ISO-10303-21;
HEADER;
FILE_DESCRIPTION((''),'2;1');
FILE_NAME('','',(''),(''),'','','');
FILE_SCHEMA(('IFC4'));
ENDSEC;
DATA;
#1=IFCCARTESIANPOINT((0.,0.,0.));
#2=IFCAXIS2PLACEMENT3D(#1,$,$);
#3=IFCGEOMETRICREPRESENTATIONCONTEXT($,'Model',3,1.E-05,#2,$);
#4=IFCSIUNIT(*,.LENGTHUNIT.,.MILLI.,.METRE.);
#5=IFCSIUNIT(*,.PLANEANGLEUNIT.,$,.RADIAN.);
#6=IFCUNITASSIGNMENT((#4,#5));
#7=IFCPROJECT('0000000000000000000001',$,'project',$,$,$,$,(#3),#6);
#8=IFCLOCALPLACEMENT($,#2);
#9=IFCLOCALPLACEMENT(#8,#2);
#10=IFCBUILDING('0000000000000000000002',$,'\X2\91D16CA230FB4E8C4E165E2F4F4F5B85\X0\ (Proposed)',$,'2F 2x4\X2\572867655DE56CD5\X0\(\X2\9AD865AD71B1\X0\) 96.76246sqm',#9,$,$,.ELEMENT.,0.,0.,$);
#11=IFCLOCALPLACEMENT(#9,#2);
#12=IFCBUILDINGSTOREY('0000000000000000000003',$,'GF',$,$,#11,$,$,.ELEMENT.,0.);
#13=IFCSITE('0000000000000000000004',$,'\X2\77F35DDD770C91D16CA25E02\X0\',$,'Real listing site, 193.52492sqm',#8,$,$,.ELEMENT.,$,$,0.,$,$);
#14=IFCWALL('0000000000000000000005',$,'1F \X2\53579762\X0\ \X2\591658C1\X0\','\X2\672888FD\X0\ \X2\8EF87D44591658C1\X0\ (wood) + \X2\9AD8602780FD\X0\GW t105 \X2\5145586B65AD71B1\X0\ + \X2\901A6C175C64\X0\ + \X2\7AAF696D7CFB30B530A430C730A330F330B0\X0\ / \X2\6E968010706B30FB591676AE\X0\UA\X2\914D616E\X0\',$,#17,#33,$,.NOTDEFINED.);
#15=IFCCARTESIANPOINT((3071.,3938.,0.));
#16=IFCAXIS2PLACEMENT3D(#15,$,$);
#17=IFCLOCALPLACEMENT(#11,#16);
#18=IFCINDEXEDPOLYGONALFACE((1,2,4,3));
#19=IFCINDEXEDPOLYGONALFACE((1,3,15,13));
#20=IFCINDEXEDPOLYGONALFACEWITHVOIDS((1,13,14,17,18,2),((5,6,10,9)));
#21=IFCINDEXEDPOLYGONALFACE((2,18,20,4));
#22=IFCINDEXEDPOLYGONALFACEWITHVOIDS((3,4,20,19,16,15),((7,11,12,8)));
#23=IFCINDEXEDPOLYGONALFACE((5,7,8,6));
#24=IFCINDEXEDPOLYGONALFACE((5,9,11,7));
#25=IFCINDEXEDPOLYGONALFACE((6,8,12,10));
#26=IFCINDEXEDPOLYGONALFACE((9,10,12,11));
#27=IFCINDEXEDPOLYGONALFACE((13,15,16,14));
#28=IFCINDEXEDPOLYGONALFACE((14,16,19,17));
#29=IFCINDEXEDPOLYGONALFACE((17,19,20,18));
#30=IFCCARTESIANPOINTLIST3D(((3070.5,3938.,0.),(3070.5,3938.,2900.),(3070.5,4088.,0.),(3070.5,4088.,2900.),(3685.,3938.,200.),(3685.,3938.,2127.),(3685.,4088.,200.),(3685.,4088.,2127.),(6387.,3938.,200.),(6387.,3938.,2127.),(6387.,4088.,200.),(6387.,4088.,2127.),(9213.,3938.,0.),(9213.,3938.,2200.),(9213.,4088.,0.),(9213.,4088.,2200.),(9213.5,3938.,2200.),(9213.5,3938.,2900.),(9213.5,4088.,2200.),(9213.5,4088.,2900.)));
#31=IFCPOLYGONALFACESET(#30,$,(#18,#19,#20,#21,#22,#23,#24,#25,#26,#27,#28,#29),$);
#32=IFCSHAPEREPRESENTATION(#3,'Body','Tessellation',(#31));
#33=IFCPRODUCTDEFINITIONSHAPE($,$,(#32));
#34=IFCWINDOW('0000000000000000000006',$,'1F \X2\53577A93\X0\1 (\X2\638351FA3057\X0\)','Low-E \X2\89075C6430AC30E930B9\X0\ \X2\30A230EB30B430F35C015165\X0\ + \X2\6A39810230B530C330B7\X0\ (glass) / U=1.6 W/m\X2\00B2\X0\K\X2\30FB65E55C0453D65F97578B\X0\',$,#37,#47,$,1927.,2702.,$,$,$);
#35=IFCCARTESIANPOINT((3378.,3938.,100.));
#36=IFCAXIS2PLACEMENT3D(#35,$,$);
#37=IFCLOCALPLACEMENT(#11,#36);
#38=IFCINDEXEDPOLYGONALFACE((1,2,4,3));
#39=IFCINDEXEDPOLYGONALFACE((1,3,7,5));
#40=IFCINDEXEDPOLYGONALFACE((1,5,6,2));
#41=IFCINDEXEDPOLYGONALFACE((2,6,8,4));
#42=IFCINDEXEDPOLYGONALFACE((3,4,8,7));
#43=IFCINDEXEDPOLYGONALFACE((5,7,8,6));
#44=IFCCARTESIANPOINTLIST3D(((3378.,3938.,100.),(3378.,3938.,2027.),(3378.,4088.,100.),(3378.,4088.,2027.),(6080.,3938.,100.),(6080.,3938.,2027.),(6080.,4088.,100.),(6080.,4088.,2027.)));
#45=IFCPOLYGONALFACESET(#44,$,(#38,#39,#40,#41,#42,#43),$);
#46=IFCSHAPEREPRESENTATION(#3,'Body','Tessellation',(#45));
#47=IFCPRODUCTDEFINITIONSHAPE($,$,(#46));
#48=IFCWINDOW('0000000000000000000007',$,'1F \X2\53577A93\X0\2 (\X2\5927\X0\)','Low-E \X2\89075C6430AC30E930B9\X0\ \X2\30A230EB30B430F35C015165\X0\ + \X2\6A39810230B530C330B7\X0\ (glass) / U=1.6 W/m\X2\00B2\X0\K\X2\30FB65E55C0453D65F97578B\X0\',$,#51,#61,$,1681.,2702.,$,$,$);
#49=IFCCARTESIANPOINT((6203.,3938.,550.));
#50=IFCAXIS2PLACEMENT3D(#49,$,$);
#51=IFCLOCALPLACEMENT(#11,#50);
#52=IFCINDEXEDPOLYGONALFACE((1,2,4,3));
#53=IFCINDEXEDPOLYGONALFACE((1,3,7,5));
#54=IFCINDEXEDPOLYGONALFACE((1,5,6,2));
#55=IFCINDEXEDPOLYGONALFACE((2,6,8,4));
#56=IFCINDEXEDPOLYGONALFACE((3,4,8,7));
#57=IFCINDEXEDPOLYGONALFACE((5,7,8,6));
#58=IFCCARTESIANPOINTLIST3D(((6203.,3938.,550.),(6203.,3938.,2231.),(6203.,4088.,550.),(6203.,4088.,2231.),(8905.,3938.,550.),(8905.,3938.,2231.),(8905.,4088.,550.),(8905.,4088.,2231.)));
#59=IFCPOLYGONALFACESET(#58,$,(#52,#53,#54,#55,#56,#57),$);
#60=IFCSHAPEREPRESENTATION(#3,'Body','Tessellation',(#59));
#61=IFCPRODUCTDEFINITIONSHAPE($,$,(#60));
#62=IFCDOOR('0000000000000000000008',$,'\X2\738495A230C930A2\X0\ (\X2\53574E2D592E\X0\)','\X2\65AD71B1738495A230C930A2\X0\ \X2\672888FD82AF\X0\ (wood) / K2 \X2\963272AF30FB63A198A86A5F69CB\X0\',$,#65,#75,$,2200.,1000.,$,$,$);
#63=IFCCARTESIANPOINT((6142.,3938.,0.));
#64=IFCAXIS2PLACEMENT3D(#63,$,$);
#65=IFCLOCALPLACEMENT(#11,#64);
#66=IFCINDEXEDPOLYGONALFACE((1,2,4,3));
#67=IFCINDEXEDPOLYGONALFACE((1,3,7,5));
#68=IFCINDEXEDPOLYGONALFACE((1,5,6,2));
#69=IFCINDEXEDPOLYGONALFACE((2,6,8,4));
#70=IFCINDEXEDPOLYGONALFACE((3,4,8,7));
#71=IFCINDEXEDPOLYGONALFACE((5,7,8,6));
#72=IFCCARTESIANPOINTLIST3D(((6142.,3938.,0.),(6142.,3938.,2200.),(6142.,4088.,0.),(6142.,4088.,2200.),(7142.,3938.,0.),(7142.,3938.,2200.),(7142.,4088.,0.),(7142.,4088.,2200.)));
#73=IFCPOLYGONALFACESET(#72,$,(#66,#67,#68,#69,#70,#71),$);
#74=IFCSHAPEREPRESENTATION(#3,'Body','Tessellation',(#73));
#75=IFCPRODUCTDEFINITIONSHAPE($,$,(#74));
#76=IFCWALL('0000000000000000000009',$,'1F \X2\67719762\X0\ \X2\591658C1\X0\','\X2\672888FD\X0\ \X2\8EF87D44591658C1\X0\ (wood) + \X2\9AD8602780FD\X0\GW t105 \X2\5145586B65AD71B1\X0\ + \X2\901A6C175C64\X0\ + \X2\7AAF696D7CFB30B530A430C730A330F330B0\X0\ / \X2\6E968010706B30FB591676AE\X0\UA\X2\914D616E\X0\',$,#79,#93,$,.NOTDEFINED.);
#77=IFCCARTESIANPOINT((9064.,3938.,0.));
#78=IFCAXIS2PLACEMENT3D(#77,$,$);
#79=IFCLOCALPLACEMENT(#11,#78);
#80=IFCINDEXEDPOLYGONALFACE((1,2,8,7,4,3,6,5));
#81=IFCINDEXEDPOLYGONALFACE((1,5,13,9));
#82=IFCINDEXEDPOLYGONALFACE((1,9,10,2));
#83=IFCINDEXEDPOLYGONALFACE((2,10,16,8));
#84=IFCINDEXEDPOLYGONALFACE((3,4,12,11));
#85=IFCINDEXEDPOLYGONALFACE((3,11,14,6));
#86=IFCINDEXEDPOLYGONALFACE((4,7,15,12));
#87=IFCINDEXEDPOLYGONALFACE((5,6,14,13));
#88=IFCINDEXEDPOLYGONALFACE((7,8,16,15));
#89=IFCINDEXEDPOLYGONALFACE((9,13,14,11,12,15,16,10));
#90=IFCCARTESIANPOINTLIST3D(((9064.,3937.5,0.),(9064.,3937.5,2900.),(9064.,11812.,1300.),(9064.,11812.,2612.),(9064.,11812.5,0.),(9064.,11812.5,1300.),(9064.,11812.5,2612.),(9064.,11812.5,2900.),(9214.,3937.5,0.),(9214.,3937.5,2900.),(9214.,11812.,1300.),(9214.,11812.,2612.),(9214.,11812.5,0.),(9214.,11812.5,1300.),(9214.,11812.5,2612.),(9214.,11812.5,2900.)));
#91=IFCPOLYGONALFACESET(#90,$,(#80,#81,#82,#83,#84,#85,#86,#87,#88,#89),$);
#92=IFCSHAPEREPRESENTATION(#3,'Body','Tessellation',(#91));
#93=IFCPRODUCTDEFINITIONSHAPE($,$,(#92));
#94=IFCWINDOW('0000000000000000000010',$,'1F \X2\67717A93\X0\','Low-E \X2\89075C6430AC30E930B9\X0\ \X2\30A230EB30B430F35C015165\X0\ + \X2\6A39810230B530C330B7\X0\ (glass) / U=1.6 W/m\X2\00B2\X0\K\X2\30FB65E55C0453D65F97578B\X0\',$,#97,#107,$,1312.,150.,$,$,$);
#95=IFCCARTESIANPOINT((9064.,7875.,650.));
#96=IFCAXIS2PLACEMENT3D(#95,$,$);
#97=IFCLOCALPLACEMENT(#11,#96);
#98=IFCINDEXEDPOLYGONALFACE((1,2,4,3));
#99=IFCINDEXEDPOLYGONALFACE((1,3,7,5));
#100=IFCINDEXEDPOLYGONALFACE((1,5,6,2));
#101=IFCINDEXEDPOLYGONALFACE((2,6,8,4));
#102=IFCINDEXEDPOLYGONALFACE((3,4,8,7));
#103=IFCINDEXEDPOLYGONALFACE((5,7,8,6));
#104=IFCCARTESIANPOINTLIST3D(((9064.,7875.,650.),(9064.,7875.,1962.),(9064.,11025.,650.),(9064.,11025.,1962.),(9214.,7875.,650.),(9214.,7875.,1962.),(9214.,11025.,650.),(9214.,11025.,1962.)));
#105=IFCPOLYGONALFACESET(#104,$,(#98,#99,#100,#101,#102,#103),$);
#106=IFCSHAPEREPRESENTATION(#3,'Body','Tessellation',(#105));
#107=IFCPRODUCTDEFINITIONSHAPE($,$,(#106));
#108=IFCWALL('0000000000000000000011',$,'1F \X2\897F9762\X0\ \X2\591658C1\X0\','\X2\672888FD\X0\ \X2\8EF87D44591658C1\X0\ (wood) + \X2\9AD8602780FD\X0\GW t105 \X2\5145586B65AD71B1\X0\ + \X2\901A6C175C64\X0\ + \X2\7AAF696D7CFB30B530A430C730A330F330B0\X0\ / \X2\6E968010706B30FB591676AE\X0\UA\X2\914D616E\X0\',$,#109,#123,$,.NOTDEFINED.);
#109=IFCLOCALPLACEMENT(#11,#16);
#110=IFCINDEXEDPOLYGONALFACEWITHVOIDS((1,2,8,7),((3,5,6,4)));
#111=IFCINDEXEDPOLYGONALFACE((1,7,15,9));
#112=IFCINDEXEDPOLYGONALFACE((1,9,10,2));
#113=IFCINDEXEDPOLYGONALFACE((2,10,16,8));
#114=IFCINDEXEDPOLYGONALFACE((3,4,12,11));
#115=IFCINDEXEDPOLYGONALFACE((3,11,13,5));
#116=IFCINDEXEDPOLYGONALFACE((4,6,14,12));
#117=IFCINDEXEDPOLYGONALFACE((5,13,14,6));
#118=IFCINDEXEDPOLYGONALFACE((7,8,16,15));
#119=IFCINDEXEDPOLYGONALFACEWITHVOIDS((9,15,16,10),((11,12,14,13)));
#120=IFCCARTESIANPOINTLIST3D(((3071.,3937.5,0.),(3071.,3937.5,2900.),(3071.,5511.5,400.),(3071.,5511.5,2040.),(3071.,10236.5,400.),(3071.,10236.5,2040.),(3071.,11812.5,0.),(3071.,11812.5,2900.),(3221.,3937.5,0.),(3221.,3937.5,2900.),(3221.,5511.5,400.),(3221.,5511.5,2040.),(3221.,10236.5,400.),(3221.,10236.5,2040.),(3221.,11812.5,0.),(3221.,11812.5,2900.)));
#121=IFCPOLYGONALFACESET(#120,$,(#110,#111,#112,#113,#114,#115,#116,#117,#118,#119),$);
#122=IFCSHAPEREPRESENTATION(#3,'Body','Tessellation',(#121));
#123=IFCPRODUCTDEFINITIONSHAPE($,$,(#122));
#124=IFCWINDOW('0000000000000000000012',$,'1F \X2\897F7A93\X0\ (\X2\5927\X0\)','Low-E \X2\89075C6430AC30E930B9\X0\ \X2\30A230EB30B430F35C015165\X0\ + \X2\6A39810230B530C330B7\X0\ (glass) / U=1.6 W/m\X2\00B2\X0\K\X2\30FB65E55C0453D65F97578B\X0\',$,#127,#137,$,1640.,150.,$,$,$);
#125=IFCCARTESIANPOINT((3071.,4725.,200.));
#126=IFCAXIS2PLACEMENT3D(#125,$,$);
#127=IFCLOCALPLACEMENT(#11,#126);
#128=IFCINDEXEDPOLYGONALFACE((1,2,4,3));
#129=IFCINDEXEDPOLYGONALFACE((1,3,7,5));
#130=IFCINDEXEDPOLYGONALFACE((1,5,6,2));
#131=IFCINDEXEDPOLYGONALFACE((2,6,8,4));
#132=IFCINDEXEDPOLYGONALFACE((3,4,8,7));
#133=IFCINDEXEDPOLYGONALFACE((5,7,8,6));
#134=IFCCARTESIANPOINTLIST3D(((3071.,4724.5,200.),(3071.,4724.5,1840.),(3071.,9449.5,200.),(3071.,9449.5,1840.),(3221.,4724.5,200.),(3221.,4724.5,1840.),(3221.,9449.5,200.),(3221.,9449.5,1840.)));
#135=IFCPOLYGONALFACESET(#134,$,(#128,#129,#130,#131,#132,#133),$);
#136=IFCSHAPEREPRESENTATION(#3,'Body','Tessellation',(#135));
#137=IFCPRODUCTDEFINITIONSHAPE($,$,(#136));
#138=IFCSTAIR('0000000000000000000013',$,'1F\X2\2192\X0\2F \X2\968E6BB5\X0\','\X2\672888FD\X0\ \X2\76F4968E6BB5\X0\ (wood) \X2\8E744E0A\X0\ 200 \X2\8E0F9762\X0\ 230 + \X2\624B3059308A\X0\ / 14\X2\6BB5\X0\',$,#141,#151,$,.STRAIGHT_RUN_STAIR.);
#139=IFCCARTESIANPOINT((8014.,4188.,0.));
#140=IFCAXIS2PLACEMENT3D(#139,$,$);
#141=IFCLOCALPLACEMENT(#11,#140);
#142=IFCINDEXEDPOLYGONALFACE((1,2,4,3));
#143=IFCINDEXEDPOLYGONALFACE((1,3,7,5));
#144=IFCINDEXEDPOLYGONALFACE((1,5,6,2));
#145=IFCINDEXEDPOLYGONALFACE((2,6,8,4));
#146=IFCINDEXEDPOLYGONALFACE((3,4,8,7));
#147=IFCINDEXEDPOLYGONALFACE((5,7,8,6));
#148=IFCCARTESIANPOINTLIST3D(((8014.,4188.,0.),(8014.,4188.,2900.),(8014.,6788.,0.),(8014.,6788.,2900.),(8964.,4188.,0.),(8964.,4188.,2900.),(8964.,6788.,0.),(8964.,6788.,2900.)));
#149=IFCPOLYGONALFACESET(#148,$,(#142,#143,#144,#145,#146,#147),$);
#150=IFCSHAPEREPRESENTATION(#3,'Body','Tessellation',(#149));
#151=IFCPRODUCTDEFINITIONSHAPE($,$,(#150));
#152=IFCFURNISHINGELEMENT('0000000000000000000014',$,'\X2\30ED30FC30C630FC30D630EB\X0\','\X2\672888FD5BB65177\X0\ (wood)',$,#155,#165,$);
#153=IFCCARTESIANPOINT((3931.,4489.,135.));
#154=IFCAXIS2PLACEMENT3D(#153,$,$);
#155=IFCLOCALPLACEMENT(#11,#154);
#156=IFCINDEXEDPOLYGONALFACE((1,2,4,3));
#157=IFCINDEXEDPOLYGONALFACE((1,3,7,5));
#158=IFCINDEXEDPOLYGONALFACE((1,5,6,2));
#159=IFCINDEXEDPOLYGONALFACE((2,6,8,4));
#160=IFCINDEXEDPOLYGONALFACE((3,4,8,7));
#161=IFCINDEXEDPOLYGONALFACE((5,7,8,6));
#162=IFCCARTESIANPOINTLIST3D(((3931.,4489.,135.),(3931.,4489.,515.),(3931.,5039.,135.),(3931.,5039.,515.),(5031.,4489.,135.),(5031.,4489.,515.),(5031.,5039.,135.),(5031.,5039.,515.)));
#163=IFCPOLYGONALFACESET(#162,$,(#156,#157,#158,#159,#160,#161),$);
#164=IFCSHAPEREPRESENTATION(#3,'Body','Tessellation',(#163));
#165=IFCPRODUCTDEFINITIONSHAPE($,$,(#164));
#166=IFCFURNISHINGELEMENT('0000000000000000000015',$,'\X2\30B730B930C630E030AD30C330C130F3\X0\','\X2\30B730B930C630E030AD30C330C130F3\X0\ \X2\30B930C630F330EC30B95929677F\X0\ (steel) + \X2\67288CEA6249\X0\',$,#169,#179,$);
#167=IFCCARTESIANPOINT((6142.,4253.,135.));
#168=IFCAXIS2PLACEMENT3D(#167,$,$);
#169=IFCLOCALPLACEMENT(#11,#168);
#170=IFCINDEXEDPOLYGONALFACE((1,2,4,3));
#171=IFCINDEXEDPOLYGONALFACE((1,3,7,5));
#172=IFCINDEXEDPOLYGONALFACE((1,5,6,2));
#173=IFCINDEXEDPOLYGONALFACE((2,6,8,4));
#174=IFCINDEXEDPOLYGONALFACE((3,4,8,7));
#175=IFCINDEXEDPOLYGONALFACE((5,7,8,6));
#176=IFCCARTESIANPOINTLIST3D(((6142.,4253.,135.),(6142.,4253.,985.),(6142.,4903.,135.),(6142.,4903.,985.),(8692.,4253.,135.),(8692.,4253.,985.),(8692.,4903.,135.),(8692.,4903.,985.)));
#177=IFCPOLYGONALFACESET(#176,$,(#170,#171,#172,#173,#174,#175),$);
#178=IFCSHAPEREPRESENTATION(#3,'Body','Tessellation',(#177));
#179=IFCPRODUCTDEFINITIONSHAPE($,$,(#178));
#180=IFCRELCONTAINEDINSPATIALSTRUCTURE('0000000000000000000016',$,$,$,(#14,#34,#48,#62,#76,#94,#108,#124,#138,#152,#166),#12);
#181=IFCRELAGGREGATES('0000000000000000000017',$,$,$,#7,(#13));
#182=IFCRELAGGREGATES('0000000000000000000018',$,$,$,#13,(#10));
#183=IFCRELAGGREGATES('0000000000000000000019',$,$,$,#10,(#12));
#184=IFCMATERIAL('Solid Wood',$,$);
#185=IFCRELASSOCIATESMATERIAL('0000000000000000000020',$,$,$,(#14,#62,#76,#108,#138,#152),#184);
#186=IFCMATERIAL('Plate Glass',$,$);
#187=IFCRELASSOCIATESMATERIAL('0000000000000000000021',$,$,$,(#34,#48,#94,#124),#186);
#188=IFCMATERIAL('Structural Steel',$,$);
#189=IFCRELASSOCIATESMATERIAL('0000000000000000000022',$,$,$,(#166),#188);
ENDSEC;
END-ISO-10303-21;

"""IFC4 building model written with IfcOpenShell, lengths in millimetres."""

from ifc_helpers import new_model, si_unit, frame, frame_2d, origin, place, context, project, spatial, rectangle, extrude, material, element, fill, save


model = new_model("IFC4")

# Units and contexts
model_context = context("Model", 3, precision=1e-05, world=origin())
ifc_project = project(units=[si_unit("LENGTHUNIT", "METRE", prefix="MILLI"), si_unit("PLANEANGLEUNIT", "RADIAN")], contexts=[model_context])

# Site, building, storey
site_placement = place(None, origin())
site = spatial("IfcSite", under=ifc_project, at=site_placement, Name="石川県金沢市", ObjectType="Real listing site, 193.52492sqm", CompositionType="ELEMENT", RefElevation=0.0)
building_placement = place(site_placement, origin())
building = spatial("IfcBuilding", under=site, at=building_placement, Name="金沢・二世帯住宅 (Proposed)", ObjectType="2F 2x4在来工法(高断熱) 96.76246sqm", CompositionType="ELEMENT", ElevationOfRefHeight=0.0, ElevationOfTerrain=0.0)
storey_placement = place(building_placement, origin())
storey = spatial("IfcBuildingStorey", under=building, at=storey_placement, Name="GF", CompositionType="ELEMENT", Elevation=0.0)

# Shared definitions
ifc_material_1 = material(Name="Solid Wood")

# Wall, openings, windows, door
wall_1_placement = place(storey_placement, frame((3071.0, 3938.0, 0.0)))
wall_1 = element("IfcWall", 1, at=wall_1_placement, inside=storey, material=ifc_material_1, Name="1F 南面 外壁", Description="木製 軸組外壁 (wood) + 高性能GW t105 充填断熱 + 通気層 + 窯業系サイディング / 準耐火・外皮UA配慮", PredefinedType="NOTDEFINED", context=model_context, shape_type="SweptSolid", body=[
    extrude(rectangle(XDim=6143.0, YDim=150.0, at=frame_2d((3071.0, 75.0))), frame((3071.0, 3938.0, 0.0)), (0.0, 0.0, 1.0), 2900.0),
])
opening_1_placement = place(storey_placement, frame((3378.0, 3938.0, 100.0)))
opening_1 = element("IfcOpeningElement", 2, at=opening_1_placement, cuts=wall_1, PredefinedType="NOTDEFINED", context=model_context, shape_type="SweptSolid", body=[
    extrude(rectangle(XDim=2702.0, YDim=150.0, at=frame_2d((1351.0, 75.0))), frame((3378.0, 3938.0, 100.0)), (0.0, 0.0, 1.0), 1927.0),
])
opening_2_placement = place(storey_placement, frame((6203.0, 3938.0, 550.0)))
opening_2 = element("IfcOpeningElement", 3, at=opening_2_placement, cuts=wall_1, PredefinedType="NOTDEFINED", context=model_context, shape_type="SweptSolid", body=[
    extrude(rectangle(XDim=2702.0, YDim=150.0, at=frame_2d((1351.0, 75.0))), frame((6203.0, 3938.0, 550.0)), (0.0, 0.0, 1.0), 1681.0),
])
opening_3_placement = place(storey_placement, frame((6142.0, 3938.0, 0.0)))
opening_3 = element("IfcOpeningElement", 4, at=opening_3_placement, cuts=wall_1, PredefinedType="NOTDEFINED", context=model_context, shape_type="SweptSolid", body=[
    extrude(rectangle(XDim=1000.0, YDim=150.0, at=frame_2d((500.0, 75.0))), frame((6142.0, 3938.0, 0.0)), (0.0, 0.0, 1.0), 2200.0),
])
ifc_material_2 = material(Name="Plate Glass")
window_1_placement = place(storey_placement, frame((3378.0, 3938.0, 100.0)))
window_1 = element("IfcWindow", 5, at=window_1_placement, inside=storey, material=ifc_material_2, Name="1F 南窓1 (掃出し)", Description="Low-E 複層ガラス アルゴン封入 + 樹脂サッシ (glass) / U=1.6 W/m²K・日射取得型", OverallHeight=1927.0, OverallWidth=2702.0, context=model_context, shape_type="SweptSolid", body=[
    extrude(rectangle(XDim=2702.0, YDim=150.0, at=frame_2d((1351.0, 75.0))), frame((3378.0, 3938.0, 100.0)), (0.0, 0.0, 1.0), 1927.0),
])
fill(opening_1, window_1)
window_2_placement = place(storey_placement, frame((6203.0, 3938.0, 550.0)))
window_2 = element("IfcWindow", 6, at=window_2_placement, inside=storey, material=ifc_material_2, Name="1F 南窓2 (大)", Description="Low-E 複層ガラス アルゴン封入 + 樹脂サッシ (glass) / U=1.6 W/m²K・日射取得型", OverallHeight=1681.0, OverallWidth=2702.0, context=model_context, shape_type="SweptSolid", body=[
    extrude(rectangle(XDim=2702.0, YDim=150.0, at=frame_2d((1351.0, 75.0))), frame((6203.0, 3938.0, 550.0)), (0.0, 0.0, 1.0), 1681.0),
])
fill(opening_2, window_2)
door_placement = place(storey_placement, frame((6142.0, 3938.0, 0.0)))
door = element("IfcDoor", 7, at=door_placement, inside=storey, material=ifc_material_1, Name="玄関ドア (南中央)", Description="断熱玄関ドア 木製芯 (wood) / K2 防犯・採風機構", OverallHeight=2200.0, OverallWidth=1000.0, context=model_context, shape_type="SweptSolid", body=[
    extrude(rectangle(XDim=1000.0, YDim=150.0, at=frame_2d((500.0, 75.0))), frame((6142.0, 3938.0, 0.0)), (0.0, 0.0, 1.0), 2200.0),
])
fill(opening_3, door)

# Walls, openings, windows
wall_2_placement = place(storey_placement, frame((9064.0, 3938.0, 0.0)))
wall_2 = element("IfcWall", 8, at=wall_2_placement, inside=storey, material=ifc_material_1, Name="1F 東面 外壁", Description="木製 軸組外壁 (wood) + 高性能GW t105 充填断熱 + 通気層 + 窯業系サイディング / 準耐火・外皮UA配慮", PredefinedType="NOTDEFINED", context=model_context, shape_type="SweptSolid", body=[
    extrude(rectangle(XDim=150.0, YDim=7875.0, at=frame_2d((75.0, 3937.0))), frame((9064.0, 3938.0, 0.0)), (0.0, 0.0, 1.0), 2900.0),
])
opening_4_placement = place(storey_placement, frame((9064.0, 7875.0, 650.0)))
opening_4 = element("IfcOpeningElement", 9, at=opening_4_placement, cuts=wall_2, PredefinedType="NOTDEFINED", context=model_context, shape_type="SweptSolid", body=[
    extrude(rectangle(XDim=150.0, YDim=3150.0, at=frame_2d((75.0, 1575.0))), frame((9064.0, 7875.0, 650.0)), (0.0, 0.0, 1.0), 1312.0),
])
window_3_placement = place(storey_placement, frame((9064.0, 7875.0, 650.0)))
window_3 = element("IfcWindow", 10, at=window_3_placement, inside=storey, material=ifc_material_2, Name="1F 東窓", Description="Low-E 複層ガラス アルゴン封入 + 樹脂サッシ (glass) / U=1.6 W/m²K・日射取得型", OverallHeight=1312.0, OverallWidth=150.0, context=model_context, shape_type="SweptSolid", body=[
    extrude(rectangle(XDim=150.0, YDim=3150.0, at=frame_2d((75.0, 1575.0))), frame((9064.0, 7875.0, 650.0)), (0.0, 0.0, 1.0), 1312.0),
])
fill(opening_4, window_3)
wall_3_placement = place(storey_placement, frame((3071.0, 3938.0, 0.0)))
wall_3 = element("IfcWall", 11, at=wall_3_placement, inside=storey, material=ifc_material_1, Name="1F 西面 外壁", Description="木製 軸組外壁 (wood) + 高性能GW t105 充填断熱 + 通気層 + 窯業系サイディング / 準耐火・外皮UA配慮", PredefinedType="NOTDEFINED", context=model_context, shape_type="SweptSolid", body=[
    extrude(rectangle(XDim=150.0, YDim=7875.0, at=frame_2d((75.0, 3937.0))), frame((3071.0, 3938.0, 0.0)), (0.0, 0.0, 1.0), 2900.0),
])
opening_5_placement = place(storey_placement, frame((3071.0, 4725.0, 200.0)))
opening_5 = element("IfcOpeningElement", 12, at=opening_5_placement, cuts=wall_3, PredefinedType="NOTDEFINED", context=model_context, shape_type="SweptSolid", body=[
    extrude(rectangle(XDim=150.0, YDim=4725.0, at=frame_2d((75.0, 2362.0))), frame((3071.0, 4725.0, 200.0)), (0.0, 0.0, 1.0), 1640.0),
])
window_4_placement = place(storey_placement, frame((3071.0, 4725.0, 200.0)))
window_4 = element("IfcWindow", 13, at=window_4_placement, inside=storey, material=ifc_material_2, Name="1F 西窓 (大)", Description="Low-E 複層ガラス アルゴン封入 + 樹脂サッシ (glass) / U=1.6 W/m²K・日射取得型", OverallHeight=1640.0, OverallWidth=150.0, context=model_context, shape_type="SweptSolid", body=[
    extrude(rectangle(XDim=150.0, YDim=4725.0, at=frame_2d((75.0, 2362.0))), frame((3071.0, 4725.0, 200.0)), (0.0, 0.0, 1.0), 1640.0),
])
fill(opening_5, window_4)

# Stair
stair_placement = place(storey_placement, frame((8014.0, 4188.0, 0.0)))
element("IfcStair", 14, at=stair_placement, inside=storey, material=ifc_material_1, Name="1F→2F 階段", Description="木製 直階段 (wood) 蹴上 200 踏面 230 + 手すり / 14段", PredefinedType="STRAIGHT_RUN_STAIR", context=model_context, shape_type="SweptSolid", body=[
    extrude(rectangle(XDim=950.0, YDim=2600.0, at=frame_2d((475.0, 1300.0))), frame((8014.0, 4188.0, 0.0)), (0.0, 0.0, 1.0), 2900.0),
])

# Furnishing elements
furnishing_1_placement = place(storey_placement, frame((3931.0, 4489.0, 135.0)))
element("IfcFurnishingElement", 15, at=furnishing_1_placement, inside=storey, material=ifc_material_1, Name="ローテーブル", Description="木製家具 (wood)", context=model_context, shape_type="SweptSolid", body=[
    extrude(rectangle(XDim=1100.0, YDim=550.0, at=frame_2d((550.0, 275.0))), frame((3931.0, 4489.0, 135.0)), (0.0, 0.0, 1.0), 380.0),
])
ifc_material_3 = material(Name="Structural Steel")
furnishing_2_placement = place(storey_placement, frame((6142.0, 4253.0, 135.0)))
element("IfcFurnishingElement", 16, at=furnishing_2_placement, inside=storey, material=ifc_material_3, Name="システムキッチン", Description="システムキッチン ステンレス天板 (steel) + 木質扉", context=model_context, shape_type="SweptSolid", body=[
    extrude(rectangle(XDim=2550.0, YDim=650.0, at=frame_2d((1275.0, 325.0))), frame((6142.0, 4253.0, 135.0)), (0.0, 0.0, 1.0), 850.0),
])

save(model, "model.ifc")
